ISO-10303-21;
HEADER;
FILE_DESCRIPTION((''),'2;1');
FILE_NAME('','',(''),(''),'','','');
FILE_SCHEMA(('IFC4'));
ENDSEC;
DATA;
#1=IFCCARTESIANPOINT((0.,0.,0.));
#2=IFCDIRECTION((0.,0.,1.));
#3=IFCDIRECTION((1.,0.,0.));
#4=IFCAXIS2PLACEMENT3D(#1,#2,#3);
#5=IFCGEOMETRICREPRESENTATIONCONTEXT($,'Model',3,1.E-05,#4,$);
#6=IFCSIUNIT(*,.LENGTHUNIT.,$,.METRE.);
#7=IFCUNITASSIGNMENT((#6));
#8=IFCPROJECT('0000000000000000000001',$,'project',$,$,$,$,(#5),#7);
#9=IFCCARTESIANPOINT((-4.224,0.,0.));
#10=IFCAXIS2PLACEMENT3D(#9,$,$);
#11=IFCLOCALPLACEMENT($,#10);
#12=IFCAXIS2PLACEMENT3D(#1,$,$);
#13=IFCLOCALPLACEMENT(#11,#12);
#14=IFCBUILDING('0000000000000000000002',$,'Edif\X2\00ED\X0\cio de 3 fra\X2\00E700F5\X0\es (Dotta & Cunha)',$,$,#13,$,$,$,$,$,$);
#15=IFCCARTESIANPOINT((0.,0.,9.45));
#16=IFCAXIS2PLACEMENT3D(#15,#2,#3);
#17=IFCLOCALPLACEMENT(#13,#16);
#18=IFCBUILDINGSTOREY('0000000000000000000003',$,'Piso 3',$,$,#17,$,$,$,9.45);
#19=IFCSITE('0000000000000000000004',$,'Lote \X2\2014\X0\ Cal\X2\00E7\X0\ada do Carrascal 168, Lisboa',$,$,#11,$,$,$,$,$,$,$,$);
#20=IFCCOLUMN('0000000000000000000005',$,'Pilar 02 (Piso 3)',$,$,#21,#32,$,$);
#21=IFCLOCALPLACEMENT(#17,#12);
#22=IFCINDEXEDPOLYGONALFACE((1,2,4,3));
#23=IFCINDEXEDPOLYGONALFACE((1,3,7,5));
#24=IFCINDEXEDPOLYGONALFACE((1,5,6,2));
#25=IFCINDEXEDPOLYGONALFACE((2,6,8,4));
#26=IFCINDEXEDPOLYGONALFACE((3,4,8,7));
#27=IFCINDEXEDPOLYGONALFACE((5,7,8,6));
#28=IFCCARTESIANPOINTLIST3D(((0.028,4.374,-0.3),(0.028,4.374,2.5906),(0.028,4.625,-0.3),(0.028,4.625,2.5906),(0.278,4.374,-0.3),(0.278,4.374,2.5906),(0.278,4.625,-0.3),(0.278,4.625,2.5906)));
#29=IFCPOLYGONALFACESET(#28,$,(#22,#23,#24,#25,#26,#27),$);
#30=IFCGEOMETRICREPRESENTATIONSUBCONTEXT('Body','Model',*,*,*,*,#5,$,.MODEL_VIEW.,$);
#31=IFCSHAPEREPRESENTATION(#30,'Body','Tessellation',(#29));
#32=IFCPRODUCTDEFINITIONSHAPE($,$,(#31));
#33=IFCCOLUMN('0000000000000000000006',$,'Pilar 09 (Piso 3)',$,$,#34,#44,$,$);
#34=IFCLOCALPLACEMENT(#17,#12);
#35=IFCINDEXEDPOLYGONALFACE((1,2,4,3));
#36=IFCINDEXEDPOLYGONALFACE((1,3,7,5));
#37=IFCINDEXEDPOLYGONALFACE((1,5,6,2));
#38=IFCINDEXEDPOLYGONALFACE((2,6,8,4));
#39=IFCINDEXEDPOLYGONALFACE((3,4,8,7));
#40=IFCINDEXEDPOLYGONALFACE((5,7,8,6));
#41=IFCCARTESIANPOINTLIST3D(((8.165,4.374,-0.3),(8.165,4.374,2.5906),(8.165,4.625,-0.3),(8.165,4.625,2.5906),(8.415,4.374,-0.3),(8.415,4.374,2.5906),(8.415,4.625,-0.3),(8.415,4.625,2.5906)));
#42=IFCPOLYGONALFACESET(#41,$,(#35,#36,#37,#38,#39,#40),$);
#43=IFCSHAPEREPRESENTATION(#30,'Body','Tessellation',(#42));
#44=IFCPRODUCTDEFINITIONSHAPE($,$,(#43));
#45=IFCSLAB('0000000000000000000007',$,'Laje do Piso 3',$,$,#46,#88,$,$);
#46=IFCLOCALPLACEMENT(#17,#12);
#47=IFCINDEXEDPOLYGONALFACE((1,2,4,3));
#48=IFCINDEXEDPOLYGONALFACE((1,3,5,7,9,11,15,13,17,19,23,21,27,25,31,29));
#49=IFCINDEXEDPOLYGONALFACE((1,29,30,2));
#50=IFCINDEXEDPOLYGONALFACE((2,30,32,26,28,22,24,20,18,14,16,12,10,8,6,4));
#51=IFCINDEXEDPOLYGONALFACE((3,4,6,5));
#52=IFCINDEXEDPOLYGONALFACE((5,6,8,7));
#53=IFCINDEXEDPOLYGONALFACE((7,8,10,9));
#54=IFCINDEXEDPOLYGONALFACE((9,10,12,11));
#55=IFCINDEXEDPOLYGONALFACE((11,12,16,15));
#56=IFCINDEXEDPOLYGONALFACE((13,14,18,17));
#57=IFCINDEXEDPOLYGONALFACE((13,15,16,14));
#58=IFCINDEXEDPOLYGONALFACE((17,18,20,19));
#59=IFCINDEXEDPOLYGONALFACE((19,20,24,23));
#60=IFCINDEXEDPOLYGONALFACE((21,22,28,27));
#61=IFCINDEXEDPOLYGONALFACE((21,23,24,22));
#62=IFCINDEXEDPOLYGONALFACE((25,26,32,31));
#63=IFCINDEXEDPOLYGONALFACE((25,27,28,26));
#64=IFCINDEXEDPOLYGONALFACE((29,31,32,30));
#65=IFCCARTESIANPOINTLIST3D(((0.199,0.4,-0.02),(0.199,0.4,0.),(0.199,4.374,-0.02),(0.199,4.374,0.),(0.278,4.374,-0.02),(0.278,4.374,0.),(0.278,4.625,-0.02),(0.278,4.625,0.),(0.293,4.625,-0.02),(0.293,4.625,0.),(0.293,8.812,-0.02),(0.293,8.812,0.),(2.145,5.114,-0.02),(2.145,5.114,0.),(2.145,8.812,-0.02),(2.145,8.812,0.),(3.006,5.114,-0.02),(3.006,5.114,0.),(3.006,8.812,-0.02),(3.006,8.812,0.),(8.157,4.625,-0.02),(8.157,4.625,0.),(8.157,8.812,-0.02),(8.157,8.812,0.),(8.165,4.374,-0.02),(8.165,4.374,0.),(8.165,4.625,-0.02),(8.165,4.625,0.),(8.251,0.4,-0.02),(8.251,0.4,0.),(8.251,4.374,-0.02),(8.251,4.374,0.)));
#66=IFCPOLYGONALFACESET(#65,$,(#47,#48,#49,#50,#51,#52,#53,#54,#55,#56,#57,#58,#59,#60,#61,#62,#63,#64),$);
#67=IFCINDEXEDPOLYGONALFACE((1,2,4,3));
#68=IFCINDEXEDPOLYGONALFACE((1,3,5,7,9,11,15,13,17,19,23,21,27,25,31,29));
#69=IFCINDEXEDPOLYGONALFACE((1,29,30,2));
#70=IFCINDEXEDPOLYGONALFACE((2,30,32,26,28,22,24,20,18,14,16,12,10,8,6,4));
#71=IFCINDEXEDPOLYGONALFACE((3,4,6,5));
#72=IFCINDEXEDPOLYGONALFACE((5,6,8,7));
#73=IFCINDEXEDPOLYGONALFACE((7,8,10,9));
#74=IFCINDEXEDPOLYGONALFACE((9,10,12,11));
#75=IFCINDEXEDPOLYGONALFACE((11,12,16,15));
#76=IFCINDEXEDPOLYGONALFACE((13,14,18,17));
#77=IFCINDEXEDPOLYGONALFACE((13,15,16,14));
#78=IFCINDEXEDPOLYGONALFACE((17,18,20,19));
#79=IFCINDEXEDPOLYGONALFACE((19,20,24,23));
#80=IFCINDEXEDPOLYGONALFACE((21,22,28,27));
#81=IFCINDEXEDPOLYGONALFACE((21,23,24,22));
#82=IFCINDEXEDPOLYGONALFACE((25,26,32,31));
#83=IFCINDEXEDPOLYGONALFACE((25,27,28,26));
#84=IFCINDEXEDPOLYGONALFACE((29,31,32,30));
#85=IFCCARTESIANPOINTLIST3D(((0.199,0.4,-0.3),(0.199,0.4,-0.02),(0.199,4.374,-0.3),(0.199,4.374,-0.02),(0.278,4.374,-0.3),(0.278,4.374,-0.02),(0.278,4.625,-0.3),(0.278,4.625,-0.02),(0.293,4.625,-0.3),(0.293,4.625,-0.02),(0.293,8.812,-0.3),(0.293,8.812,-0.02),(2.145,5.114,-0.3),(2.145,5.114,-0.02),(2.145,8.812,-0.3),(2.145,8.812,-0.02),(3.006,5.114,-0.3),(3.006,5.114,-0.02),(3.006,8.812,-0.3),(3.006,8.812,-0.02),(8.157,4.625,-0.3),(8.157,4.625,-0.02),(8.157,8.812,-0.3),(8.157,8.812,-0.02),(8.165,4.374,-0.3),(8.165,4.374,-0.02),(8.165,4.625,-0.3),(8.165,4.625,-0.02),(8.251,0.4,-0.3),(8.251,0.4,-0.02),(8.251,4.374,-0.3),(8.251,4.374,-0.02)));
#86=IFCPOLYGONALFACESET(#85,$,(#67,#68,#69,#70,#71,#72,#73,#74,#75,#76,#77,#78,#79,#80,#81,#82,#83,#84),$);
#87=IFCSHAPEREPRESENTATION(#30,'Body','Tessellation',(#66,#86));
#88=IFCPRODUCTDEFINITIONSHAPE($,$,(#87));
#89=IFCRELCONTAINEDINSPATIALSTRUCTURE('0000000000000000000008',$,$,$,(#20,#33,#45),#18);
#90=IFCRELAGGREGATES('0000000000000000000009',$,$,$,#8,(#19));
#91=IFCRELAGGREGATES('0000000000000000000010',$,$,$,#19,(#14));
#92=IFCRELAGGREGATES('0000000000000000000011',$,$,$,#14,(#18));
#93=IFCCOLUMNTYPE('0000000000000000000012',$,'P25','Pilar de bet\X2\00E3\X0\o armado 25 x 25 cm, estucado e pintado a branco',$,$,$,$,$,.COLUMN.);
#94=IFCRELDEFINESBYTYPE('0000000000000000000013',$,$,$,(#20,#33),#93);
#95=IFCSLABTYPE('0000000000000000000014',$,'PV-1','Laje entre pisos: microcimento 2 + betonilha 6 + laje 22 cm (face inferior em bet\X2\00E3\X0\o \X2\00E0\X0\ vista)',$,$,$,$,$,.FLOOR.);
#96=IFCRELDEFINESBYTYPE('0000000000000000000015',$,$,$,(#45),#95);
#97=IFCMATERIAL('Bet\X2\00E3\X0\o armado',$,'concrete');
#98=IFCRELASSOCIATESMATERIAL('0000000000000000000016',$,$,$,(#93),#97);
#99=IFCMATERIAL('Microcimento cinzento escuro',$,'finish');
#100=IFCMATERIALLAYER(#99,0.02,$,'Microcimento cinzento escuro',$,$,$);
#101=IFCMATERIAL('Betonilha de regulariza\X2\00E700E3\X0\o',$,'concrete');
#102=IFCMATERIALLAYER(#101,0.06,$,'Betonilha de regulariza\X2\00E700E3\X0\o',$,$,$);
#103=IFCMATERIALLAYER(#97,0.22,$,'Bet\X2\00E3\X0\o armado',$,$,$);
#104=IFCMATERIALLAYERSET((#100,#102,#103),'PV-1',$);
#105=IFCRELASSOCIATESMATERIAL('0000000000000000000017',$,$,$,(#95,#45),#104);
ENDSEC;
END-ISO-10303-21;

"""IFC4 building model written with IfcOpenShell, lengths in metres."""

from ifc_helpers import new_model, si_unit, frame, origin, origin_with_axes, place, context, subcontext, project, spatial, line, indexed_curve, outline, extrude, material, layer, layer_set, layer_usage, type_object, element, save


model = new_model("IFC4")

# Units and contexts
model_context = context("Model", 3, precision=1e-05, world=origin_with_axes())
body_context = subcontext(model_context, "Body", "Model", "MODEL_VIEW")
ifc_project = project(units=[si_unit("LENGTHUNIT", "METRE")], contexts=[model_context])

# Site, building, storey
site_placement = place(None, frame((-4.224, 0.0, 0.0)))
site = spatial("IfcSite", under=ifc_project, at=site_placement, Name="Lote — Calçada do Carrascal 168, Lisboa")
building_placement = place(site_placement, origin())
building = spatial("IfcBuilding", under=site, at=building_placement, Name="Edifício de 3 frações (Dotta & Cunha)")
storey_placement = place(building_placement, frame((0.0, 0.0, 9.45), z_axis=(0.0, 0.0, 1.0), x_axis=(1.0, 0.0, 0.0)))
storey = spatial("IfcBuildingStorey", under=building, at=storey_placement, Name="Piso 3", Elevation=9.45)

# Columns
ifc_material_1 = material(Name="Betão armado", Category="concrete")
column_type = type_object("IfcColumnType", Name="P25", Description="Pilar de betão armado 25 x 25 cm, estucado e pintado a branco", PredefinedType="COLUMN", material=ifc_material_1)
column_1_placement = place(storey_placement, frame((0.0, 0.0, -0.3), z_axis=(0.0, 0.0, 1.0), x_axis=(1.0, 0.0, 0.0)))
element("IfcColumn", 1, at=column_1_placement, inside=storey, type_object=column_type, Name="Pilar 02 (Piso 3)", context=body_context, shape_type="SweptSolid", body=[
    extrude(outline(indexed_curve([(0.028, 4.625), (0.278, 4.625), (0.278, 4.374), (0.028, 4.374)], segments=[line(1, 2, 3, 4, 1)])), origin_with_axes(), (0.0, 0.0, 1.0), 2.8906),
])
column_2_placement = place(storey_placement, frame((0.0, 0.0, -0.3), z_axis=(0.0, 0.0, 1.0), x_axis=(1.0, 0.0, 0.0)))
element("IfcColumn", 2, at=column_2_placement, inside=storey, type_object=column_type, Name="Pilar 09 (Piso 3)", context=body_context, shape_type="SweptSolid", body=[
    extrude(outline(indexed_curve([(8.165, 4.625), (8.415, 4.625), (8.415, 4.374), (8.165, 4.374)], segments=[line(1, 2, 3, 4, 1)])), origin_with_axes(), (0.0, 0.0, 1.0), 2.8906),
])

# Slab
ifc_material_2 = material(Name="Microcimento cinzento escuro", Category="finish")
ifc_layer_1 = layer(ifc_material_2, 0.02, Name="Microcimento cinzento escuro")
ifc_material_3 = material(Name="Betonilha de regularização", Category="concrete")
ifc_layer_2 = layer(ifc_material_3, 0.06, Name="Betonilha de regularização")
ifc_layer_3 = layer(ifc_material_1, 0.22, Name="Betão armado")
ifc_layer_set_1 = layer_set([ifc_layer_1, ifc_layer_2, ifc_layer_3], Name="PV-1")
ifc_layer_usage_1 = layer_usage(ifc_layer_set_1, "AXIS3", "NEGATIVE", 0.3)
slab_type_1 = type_object("IfcSlabType", Name="PV-1", Description="Laje entre pisos: microcimento 2 + betonilha 6 + laje 22 cm (face inferior em betão à vista)", PredefinedType="FLOOR", material=ifc_layer_set_1)
slab_1_placement = place(storey_placement, frame((0.0, 0.0, -0.3), z_axis=(0.0, 0.0, 1.0), x_axis=(1.0, 0.0, 0.0)))
element("IfcSlab", 3, at=slab_1_placement, inside=storey, type_object=slab_type_1, material=ifc_layer_usage_1, Name="Laje do Piso 3", context=body_context, shape_type="SweptSolid", body=[
    extrude(outline(indexed_curve([(0.278, 4.374), (0.278, 4.625), (0.293, 4.625), (0.293, 8.812), (2.145, 8.812), (2.145, 5.114), (3.006, 5.114), (3.006, 8.812), (8.157, 8.812), (8.157, 4.625), (8.165, 4.625), (8.165, 4.374), (8.251, 4.374), (8.251, 0.4), (0.199, 0.4), (0.199, 4.374)], segments=[line(1, 2, 3, 4, 5, 6, 7, 8, 9, 10, 11, 12, 13, 14, 15, 16, 1)])), frame((0.0, 0.0, 0.28), z_axis=(0.0, 0.0, 1.0), x_axis=(1.0, 0.0, 0.0)), (0.0, 0.0, 1.0), 0.02),
    extrude(outline(indexed_curve([(0.278, 4.374), (0.278, 4.625), (0.293, 4.625), (0.293, 8.812), (2.145, 8.812), (2.145, 5.114), (3.006, 5.114), (3.006, 8.812), (8.157, 8.812), (8.157, 4.625), (8.165, 4.625), (8.165, 4.374), (8.251, 4.374), (8.251, 0.4), (0.199, 0.4), (0.199, 4.374)], segments=[line(1, 2, 3, 4, 5, 6, 7, 8, 9, 10, 11, 12, 13, 14, 15, 16, 1)])), origin_with_axes(), (0.0, 0.0, 1.0), 0.28),
])

save(model, "model.ifc")
